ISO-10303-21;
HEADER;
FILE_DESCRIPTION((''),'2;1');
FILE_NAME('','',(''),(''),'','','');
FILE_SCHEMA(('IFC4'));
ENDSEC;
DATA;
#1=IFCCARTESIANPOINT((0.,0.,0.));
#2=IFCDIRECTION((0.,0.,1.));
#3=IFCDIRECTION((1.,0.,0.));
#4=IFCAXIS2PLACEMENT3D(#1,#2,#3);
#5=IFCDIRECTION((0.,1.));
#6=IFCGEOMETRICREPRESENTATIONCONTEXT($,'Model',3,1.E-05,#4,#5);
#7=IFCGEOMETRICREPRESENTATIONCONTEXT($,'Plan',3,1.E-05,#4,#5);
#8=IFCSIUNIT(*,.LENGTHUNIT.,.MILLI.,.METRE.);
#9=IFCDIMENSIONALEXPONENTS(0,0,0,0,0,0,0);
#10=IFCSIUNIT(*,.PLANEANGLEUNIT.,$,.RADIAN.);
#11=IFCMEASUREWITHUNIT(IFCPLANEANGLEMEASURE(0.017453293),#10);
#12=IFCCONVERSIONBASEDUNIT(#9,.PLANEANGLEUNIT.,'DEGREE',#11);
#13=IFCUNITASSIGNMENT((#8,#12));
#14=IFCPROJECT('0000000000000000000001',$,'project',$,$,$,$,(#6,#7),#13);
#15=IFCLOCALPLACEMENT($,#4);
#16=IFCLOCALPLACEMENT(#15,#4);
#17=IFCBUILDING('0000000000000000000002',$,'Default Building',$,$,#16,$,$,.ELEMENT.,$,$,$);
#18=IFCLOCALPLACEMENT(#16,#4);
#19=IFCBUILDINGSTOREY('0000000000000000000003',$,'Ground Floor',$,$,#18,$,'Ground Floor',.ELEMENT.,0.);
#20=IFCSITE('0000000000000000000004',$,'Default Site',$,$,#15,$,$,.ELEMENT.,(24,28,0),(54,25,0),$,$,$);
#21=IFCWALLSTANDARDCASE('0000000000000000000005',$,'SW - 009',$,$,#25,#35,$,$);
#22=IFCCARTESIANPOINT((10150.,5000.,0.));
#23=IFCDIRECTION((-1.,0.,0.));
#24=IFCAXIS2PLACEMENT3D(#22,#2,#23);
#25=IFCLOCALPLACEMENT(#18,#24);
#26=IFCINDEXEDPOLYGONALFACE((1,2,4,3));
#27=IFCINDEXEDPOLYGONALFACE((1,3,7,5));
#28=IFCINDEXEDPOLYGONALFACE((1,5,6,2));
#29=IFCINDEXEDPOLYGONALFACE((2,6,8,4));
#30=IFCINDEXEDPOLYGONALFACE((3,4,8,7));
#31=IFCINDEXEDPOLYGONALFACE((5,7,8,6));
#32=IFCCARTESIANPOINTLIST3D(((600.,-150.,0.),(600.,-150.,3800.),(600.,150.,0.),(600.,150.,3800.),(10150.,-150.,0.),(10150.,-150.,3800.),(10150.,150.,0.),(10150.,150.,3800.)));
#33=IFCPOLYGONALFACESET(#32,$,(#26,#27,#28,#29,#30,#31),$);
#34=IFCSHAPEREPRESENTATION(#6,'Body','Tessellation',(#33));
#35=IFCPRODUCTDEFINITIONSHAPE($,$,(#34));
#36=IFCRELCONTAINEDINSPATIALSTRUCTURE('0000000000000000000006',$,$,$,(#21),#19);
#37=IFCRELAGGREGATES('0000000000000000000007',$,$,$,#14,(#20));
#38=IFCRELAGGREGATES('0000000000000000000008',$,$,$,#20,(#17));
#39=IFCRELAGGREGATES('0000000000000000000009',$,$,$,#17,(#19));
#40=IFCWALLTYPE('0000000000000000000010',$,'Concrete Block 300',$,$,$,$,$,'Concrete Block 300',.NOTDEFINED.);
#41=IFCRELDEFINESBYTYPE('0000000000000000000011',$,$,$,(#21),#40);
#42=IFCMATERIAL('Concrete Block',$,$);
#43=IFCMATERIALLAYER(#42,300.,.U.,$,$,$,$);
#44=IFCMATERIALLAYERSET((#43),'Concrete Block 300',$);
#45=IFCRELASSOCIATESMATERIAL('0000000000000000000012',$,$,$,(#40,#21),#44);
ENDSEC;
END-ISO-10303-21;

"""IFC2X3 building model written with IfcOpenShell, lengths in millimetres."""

from ifc_helpers import new_model, entity, si_unit, converted_unit, direction, frame, origin_with_axes, place, context, project, spatial, polyline, outline, extrude, material, layer, layer_set, layer_usage, type_object, element, save


model = new_model("IFC2X3")

# Units and contexts
model_context = context("Model", 3, precision=1e-05, world=origin_with_axes(), true_north=direction((0.0, 1.0)))
plan_context = context("Plan", 3, precision=1e-05, world=origin_with_axes(), true_north=direction((0.0, 1.0)))
ifc_project = project(units=[si_unit("LENGTHUNIT", "METRE", prefix="MILLI"), converted_unit("PLANEANGLEUNIT", "DEGREE", entity("IfcPlaneAngleMeasure", 0.017453293), si_unit("PLANEANGLEUNIT", "RADIAN"), dimensions=[0, 0, 0, 0, 0, 0, 0])], contexts=[model_context, plan_context])

# Site, building, storey
site_placement = place(None, origin_with_axes())
site = spatial("IfcSite", under=ifc_project, at=site_placement, Name="Default Site", CompositionType="ELEMENT", RefLatitude=(24, 28, 0), RefLongitude=(54, 25, 0))
building_placement = place(site_placement, origin_with_axes())
building = spatial("IfcBuilding", under=site, at=building_placement, Name="Default Building", CompositionType="ELEMENT")
storey_placement = place(building_placement, origin_with_axes())
storey = spatial("IfcBuildingStorey", under=building, at=storey_placement, Name="Ground Floor", LongName="Ground Floor", CompositionType="ELEMENT", Elevation=0.0)

# Shared definitions
ifc_material = material(Name="Concrete Block")

# Wall
ifc_layer_1 = layer(ifc_material, 300.0, ventilated="UNKNOWN")
ifc_layer_set_1 = layer_set([ifc_layer_1], Name="Concrete Block 300")
ifc_layer_usage_1 = layer_usage(ifc_layer_set_1, "AXIS2", "NEGATIVE", 150.0)
wall_type_1 = type_object("IfcWallType", Name="Concrete Block 300", ElementType="Concrete Block 300", PredefinedType="NOTDEFINED", material=ifc_layer_set_1)
wall_1_placement = place(storey_placement, frame((10150.0, 5000.0, 0.0), z_axis=(0.0, 0.0, 1.0), x_axis=(-1.0, 0.0, 0.0)))
element("IfcWallStandardCase", 1, at=wall_1_placement, inside=storey, type_object=wall_type_1, material=ifc_layer_usage_1, Name="SW - 009", context=model_context, shape_type="SweptSolid", body=[
    extrude(outline(polyline([(600.0, -150.0), (10150.0, -150.0), (10150.0, 150.0), (600.0, 150.0), (600.0, -150.0)])), origin_with_axes(), (0.0, 0.0, 1.0), 3800.0),
])

save(model, "model.ifc")
